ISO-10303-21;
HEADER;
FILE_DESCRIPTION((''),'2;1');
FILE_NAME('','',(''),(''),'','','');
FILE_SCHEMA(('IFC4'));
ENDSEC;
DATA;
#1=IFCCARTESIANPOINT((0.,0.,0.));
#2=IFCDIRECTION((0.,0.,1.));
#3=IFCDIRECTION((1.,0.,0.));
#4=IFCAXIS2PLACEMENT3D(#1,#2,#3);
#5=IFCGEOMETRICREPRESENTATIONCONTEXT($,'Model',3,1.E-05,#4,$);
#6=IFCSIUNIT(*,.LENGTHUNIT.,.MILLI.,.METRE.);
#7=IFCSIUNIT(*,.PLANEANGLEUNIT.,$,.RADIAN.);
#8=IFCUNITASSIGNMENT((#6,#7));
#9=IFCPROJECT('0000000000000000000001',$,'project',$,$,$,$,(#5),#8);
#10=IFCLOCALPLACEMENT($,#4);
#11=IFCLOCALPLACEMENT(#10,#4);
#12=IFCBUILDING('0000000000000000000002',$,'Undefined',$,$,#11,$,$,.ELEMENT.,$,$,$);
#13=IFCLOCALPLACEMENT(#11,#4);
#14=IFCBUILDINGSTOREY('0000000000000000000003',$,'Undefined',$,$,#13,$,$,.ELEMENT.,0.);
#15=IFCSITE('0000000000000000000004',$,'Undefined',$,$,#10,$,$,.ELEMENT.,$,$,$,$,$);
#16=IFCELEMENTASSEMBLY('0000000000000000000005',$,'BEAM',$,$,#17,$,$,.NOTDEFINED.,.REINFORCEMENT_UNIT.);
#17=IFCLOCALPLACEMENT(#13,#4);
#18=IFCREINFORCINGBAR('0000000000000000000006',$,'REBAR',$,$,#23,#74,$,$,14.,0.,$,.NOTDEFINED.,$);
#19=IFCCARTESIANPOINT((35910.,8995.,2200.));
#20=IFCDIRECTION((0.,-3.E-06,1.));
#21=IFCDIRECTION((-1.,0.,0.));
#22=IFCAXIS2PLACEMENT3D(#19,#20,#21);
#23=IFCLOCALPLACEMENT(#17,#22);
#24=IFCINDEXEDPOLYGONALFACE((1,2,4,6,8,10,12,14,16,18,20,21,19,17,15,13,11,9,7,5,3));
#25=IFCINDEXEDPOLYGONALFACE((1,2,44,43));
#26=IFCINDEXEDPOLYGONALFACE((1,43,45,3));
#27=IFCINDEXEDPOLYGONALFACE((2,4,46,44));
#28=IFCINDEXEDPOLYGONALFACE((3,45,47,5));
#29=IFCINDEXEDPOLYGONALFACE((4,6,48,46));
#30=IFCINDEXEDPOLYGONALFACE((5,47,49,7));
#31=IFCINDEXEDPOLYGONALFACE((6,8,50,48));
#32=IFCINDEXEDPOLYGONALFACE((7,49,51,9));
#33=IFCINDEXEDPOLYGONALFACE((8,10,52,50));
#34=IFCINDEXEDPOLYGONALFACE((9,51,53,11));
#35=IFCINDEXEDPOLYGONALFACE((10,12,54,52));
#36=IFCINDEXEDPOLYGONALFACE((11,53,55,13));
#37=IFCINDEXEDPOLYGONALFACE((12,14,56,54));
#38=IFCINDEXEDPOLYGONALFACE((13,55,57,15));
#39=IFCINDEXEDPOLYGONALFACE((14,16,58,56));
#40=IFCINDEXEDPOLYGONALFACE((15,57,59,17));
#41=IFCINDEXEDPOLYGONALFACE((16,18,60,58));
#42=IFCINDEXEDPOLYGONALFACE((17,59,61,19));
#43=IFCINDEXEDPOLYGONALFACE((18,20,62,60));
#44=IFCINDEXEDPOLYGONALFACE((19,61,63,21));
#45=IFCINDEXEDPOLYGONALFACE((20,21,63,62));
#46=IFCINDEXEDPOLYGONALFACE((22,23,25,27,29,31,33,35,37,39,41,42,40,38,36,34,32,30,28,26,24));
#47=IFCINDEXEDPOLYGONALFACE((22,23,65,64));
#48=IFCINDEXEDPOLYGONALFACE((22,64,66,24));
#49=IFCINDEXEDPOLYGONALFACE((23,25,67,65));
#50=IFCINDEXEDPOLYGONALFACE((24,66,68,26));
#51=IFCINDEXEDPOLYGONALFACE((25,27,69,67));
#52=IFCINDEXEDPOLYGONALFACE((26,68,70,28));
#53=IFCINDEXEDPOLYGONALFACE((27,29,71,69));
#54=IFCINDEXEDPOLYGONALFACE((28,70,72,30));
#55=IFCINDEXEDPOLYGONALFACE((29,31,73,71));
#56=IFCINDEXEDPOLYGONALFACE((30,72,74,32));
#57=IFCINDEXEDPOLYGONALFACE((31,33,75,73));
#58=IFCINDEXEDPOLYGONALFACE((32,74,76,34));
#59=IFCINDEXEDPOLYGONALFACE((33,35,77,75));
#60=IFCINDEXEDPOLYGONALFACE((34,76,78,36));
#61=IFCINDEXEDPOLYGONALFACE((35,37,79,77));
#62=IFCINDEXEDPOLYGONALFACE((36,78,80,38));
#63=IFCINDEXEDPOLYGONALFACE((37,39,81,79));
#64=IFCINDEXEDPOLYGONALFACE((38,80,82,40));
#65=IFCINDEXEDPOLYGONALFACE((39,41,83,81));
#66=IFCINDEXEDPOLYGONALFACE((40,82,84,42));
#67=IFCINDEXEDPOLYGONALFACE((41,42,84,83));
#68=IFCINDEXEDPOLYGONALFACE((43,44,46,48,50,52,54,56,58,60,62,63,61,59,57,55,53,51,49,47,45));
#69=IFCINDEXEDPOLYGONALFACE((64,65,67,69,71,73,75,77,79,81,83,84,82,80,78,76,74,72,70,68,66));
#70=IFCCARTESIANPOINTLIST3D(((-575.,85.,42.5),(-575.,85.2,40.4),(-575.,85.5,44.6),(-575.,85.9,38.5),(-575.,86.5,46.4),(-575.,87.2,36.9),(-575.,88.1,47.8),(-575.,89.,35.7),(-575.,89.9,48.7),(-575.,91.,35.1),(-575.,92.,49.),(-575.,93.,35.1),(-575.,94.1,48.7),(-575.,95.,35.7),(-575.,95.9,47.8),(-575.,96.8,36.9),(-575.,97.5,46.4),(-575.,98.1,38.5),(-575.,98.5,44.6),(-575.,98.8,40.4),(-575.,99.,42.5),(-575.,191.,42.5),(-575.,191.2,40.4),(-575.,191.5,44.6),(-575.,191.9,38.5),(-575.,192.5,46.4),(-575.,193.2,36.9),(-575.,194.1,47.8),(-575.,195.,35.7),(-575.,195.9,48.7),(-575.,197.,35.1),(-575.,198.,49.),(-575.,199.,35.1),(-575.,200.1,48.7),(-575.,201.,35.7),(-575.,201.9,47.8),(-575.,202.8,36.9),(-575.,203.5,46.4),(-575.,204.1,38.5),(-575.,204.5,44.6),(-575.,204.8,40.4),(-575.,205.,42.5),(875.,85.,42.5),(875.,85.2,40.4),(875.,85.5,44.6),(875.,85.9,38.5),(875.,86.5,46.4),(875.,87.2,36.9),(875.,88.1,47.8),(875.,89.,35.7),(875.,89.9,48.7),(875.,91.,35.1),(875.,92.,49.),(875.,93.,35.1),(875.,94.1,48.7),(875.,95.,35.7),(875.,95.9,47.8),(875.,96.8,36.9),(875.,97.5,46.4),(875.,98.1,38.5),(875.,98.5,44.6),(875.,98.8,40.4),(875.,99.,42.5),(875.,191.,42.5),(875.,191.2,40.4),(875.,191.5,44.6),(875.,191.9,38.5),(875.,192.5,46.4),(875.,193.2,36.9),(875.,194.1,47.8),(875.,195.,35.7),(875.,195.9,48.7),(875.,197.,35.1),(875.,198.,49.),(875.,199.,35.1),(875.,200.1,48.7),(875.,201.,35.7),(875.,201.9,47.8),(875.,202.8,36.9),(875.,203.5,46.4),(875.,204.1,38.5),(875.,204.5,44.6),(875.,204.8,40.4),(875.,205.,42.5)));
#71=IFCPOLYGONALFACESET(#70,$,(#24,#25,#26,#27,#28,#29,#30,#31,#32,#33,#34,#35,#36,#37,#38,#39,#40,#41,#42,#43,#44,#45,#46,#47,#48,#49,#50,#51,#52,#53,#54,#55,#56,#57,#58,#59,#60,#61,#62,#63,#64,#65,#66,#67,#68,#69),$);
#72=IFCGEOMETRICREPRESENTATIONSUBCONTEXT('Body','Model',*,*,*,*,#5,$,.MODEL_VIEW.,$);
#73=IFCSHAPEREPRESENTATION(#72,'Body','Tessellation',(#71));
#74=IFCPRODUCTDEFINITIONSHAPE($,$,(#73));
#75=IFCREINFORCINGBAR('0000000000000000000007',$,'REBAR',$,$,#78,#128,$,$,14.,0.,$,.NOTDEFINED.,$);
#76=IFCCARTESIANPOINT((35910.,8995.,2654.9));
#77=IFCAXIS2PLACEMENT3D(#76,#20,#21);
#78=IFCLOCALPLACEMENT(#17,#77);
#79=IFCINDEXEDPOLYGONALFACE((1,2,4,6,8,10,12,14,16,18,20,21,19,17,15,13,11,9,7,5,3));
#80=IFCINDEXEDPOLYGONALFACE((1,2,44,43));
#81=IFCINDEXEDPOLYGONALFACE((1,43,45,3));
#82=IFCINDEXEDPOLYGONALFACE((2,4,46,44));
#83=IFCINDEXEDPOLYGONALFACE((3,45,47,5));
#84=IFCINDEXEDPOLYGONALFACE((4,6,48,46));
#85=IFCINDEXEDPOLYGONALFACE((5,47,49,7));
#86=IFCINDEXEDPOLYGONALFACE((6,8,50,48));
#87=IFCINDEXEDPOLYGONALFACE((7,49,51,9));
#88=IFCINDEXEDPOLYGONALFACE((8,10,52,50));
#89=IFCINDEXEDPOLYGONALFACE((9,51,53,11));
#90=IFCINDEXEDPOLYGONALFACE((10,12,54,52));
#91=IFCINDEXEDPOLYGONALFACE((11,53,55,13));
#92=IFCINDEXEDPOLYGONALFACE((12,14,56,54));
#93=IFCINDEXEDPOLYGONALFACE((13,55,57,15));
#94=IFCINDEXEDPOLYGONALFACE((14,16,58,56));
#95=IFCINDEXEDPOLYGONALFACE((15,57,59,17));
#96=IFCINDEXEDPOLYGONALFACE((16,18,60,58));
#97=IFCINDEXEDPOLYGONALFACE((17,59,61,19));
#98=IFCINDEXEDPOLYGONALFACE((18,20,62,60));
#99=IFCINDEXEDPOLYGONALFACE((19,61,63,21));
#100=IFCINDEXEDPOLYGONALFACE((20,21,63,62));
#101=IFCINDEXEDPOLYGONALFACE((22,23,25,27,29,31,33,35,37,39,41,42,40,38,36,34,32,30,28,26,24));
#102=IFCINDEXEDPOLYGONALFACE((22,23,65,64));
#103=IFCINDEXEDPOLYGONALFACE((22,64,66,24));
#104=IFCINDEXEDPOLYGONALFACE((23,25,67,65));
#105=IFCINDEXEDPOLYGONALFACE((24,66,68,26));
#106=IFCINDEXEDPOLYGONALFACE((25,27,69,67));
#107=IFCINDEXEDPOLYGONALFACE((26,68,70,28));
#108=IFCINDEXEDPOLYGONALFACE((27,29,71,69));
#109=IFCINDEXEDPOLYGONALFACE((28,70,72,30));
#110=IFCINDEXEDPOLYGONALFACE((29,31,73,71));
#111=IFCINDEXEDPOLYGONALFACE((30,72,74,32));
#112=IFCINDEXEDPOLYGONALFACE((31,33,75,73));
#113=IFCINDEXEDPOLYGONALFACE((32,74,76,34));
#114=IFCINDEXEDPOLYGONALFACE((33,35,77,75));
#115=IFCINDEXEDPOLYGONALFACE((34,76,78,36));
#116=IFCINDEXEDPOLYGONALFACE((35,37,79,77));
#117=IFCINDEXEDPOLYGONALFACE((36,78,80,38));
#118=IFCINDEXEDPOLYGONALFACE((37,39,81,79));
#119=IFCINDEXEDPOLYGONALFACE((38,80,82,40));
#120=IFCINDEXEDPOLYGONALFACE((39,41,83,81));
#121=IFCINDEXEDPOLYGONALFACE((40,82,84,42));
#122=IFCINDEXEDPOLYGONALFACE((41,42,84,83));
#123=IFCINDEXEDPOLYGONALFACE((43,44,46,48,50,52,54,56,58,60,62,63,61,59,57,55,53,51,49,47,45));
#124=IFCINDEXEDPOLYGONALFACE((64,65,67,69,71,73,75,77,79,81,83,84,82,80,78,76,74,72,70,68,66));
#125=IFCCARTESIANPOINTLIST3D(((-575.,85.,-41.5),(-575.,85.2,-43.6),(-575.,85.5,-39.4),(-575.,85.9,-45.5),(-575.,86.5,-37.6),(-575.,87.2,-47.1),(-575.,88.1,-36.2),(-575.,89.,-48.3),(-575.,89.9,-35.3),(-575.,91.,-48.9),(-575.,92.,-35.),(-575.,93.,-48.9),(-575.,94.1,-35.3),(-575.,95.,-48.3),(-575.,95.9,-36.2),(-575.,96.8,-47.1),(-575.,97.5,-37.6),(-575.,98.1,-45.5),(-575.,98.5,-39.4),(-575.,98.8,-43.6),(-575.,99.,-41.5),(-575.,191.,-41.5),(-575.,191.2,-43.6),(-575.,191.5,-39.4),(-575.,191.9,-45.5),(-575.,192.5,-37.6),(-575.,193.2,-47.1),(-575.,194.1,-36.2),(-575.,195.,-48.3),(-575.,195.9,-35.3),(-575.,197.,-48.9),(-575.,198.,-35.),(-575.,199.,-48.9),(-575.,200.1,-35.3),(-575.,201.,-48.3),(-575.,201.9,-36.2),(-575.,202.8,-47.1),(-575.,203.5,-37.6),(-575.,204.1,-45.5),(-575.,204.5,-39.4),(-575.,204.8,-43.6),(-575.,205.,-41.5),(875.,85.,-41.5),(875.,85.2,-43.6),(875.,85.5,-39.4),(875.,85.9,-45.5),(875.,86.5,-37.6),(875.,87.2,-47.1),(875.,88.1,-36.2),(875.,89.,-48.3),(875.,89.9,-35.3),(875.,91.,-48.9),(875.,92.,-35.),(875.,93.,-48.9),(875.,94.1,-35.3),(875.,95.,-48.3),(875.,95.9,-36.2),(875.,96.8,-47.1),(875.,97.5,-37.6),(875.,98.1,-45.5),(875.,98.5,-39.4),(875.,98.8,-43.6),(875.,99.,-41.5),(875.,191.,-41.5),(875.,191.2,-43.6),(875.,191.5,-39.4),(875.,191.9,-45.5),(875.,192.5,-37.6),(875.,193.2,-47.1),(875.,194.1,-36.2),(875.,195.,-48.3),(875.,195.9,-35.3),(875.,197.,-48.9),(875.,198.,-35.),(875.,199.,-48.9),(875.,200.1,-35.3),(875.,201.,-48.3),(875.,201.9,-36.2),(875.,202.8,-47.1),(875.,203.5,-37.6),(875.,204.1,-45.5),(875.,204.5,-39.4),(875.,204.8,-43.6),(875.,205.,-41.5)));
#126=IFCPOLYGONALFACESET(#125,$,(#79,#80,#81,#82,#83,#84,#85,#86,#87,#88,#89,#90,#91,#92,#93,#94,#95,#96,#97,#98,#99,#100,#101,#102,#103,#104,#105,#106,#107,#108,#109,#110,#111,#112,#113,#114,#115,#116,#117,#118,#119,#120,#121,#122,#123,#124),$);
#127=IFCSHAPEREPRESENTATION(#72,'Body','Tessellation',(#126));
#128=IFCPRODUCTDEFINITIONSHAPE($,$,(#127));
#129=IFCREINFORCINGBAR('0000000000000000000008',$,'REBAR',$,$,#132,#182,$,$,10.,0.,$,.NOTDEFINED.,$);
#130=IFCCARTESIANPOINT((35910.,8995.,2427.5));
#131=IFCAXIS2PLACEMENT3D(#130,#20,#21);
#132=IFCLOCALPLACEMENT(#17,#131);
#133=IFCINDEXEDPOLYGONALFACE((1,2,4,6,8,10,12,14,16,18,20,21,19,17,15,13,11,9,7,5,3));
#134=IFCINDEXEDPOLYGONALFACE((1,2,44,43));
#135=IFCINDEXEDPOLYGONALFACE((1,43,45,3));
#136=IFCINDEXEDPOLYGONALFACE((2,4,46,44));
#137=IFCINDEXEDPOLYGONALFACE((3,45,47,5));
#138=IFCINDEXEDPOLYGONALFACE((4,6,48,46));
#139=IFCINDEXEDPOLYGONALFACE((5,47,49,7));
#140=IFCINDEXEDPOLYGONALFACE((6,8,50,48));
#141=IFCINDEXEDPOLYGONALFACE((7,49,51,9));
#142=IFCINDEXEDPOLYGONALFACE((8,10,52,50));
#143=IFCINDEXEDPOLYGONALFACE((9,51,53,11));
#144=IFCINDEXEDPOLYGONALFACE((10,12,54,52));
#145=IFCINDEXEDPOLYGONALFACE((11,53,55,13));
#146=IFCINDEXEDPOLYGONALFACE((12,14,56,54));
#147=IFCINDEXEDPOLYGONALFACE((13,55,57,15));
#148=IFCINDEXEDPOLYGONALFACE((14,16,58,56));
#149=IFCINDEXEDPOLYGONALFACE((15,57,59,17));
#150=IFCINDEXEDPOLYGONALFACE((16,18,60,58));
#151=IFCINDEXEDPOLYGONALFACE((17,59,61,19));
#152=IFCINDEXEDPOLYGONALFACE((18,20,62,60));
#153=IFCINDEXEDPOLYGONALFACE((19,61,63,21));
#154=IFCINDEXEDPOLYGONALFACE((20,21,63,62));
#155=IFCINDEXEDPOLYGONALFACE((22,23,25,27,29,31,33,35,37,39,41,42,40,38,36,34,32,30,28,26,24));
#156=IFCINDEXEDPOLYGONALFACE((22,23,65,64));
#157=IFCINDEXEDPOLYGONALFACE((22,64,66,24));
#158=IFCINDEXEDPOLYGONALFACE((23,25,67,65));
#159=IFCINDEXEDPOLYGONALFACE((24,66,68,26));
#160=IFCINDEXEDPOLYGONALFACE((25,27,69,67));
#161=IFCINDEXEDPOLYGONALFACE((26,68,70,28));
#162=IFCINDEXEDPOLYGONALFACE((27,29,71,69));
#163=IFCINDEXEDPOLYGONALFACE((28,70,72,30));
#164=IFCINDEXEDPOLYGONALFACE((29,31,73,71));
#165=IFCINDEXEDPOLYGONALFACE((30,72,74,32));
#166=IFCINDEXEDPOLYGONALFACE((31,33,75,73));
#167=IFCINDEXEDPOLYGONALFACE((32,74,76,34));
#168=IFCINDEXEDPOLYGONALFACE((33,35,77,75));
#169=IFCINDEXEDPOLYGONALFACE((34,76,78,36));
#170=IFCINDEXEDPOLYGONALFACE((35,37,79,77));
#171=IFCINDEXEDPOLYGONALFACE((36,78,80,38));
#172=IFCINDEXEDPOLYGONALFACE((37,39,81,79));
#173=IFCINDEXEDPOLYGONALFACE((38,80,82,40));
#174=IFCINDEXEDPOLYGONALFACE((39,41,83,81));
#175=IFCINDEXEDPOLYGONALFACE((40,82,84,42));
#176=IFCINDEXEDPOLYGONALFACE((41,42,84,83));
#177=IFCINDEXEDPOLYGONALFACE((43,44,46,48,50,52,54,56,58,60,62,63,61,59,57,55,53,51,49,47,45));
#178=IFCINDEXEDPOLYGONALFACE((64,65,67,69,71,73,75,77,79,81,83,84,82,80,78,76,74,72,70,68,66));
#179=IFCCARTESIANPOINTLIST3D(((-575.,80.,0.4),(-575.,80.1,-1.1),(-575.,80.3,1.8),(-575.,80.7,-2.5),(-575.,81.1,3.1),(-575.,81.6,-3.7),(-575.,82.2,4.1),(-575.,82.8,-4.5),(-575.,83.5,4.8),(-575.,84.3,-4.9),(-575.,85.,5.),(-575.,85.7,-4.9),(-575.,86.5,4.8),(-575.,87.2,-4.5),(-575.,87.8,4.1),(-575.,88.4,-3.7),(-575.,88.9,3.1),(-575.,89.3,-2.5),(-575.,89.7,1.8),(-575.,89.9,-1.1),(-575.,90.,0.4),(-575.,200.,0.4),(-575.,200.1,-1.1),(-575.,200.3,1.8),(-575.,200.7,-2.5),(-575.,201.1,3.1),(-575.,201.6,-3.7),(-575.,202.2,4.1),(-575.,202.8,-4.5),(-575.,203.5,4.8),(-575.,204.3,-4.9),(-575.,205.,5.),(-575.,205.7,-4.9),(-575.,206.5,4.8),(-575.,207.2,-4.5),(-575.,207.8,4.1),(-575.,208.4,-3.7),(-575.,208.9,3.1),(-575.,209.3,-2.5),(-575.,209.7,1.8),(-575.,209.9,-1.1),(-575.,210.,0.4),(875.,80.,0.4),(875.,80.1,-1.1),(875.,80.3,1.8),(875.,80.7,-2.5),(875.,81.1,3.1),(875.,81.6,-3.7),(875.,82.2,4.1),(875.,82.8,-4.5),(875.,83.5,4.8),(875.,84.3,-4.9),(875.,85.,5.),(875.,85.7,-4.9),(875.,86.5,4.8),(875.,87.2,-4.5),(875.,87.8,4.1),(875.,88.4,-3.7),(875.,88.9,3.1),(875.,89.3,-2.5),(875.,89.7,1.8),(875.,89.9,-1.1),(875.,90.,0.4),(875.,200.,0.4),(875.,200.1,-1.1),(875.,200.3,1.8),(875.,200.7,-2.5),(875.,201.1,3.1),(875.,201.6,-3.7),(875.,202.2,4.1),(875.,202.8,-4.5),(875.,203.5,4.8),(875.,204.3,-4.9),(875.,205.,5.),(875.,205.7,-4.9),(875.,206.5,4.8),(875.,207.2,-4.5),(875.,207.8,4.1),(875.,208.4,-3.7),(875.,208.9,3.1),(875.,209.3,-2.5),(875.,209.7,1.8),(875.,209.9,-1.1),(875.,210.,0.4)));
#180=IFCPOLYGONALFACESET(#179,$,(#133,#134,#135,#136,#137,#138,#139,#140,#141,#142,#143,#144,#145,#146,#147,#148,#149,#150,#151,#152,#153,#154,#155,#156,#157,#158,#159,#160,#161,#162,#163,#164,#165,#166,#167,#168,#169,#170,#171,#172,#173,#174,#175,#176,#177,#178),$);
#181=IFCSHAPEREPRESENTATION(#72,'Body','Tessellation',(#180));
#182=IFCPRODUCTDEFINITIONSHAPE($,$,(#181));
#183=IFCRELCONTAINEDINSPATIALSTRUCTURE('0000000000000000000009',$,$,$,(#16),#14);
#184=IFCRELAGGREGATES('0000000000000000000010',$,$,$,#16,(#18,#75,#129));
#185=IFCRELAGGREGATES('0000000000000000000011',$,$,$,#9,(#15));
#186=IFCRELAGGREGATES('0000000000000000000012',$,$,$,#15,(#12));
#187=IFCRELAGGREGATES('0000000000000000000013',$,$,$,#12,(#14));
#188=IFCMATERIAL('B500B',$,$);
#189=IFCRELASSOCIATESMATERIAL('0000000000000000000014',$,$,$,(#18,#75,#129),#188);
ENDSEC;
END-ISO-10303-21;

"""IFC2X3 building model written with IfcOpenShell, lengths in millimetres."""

from ifc_helpers import new_model, entity, si_unit, frame, origin_with_axes, place, context, subcontext, project, spatial, source, transform, mapped, material, element, aggregate, save


model = new_model("IFC2X3")

# Units and contexts
model_context = context("Model", 3, precision=1e-05, world=origin_with_axes())
body_context = subcontext(model_context, "Body", "Model", "MODEL_VIEW")
ifc_project = project(units=[si_unit("LENGTHUNIT", "METRE", prefix="MILLI"), si_unit("PLANEANGLEUNIT", "RADIAN")], contexts=[model_context])

# Site, building, storey
site_placement = place(None, origin_with_axes())
site = spatial("IfcSite", under=ifc_project, at=site_placement, Name="Undefined", CompositionType="ELEMENT")
building_placement = place(site_placement, origin_with_axes())
building = spatial("IfcBuilding", under=site, at=building_placement, Name="Undefined", CompositionType="ELEMENT")
storey_placement = place(building_placement, origin_with_axes())
storey = spatial("IfcBuildingStorey", under=building, at=storey_placement, Name="Undefined", CompositionType="ELEMENT", Elevation=0.0)

# Shared definitions
ifc_material_1 = material(Name="B500B")

# Element assembly, reinforcing bars
assembly_1_placement = place(storey_placement, origin_with_axes())
assembly_1 = element("IfcElementAssembly", 1, at=assembly_1_placement, inside=storey, Name="BEAM", AssemblyPlace="NOTDEFINED", PredefinedType="REINFORCEMENT_UNIT")
shared_shape_1 = source(origin_with_axes(), body_context, "Body", "AdvancedSweptSolid", [
    entity("IfcSweptDiskSolid", entity("IfcTrimmedCurve", entity("IfcLine", entity("IfcCartesianPoint", [0.0, 0.0, 0.0]), entity("IfcVector", entity("IfcDirection", [1.0, 0.0, 0.0]), 1.0)), [entity("IfcParameterValue", 0.0)], [entity("IfcParameterValue", 1449.999613)], True, "PARAMETER"), 7.0, None, 0.0, 1450.0),
])
shared_shape_2 = source(origin_with_axes(), body_context, "Body", "AdvancedSweptSolid", [
    entity("IfcSweptDiskSolid", entity("IfcTrimmedCurve", entity("IfcLine", entity("IfcCartesianPoint", [0.0, 0.0, 0.0]), entity("IfcVector", entity("IfcDirection", [1.0, 0.0, 0.0]), 1.0)), [entity("IfcParameterValue", 0.0)], [entity("IfcParameterValue", 1449.999613)], True, "PARAMETER"), 7.0, None, 0.0, 1450.0),
])
reinforcing_bar_1_placement = place(assembly_1_placement, frame((35910.0, 8995.0, 2200.0), z_axis=(0.0, -0.000003, 1.0), x_axis=(-1.0, 0.0, 0.0)))
reinforcing_bar_1 = element("IfcReinforcingBar", 2, at=reinforcing_bar_1_placement, material=ifc_material_1, Name="REBAR", BarRole="NOTDEFINED", CrossSectionArea=0.0, NominalDiameter=14.0, context=body_context, shape_type="MappedRepresentation", body=[
    mapped(shared_shape_1, transform((-575.0, 92.0, 42.0))),
    mapped(shared_shape_2, transform((-575.0, 198.0, 42.0))),
])
shared_shape_3 = source(origin_with_axes(), body_context, "Body", "AdvancedSweptSolid", [
    entity("IfcSweptDiskSolid", entity("IfcTrimmedCurve", entity("IfcLine", entity("IfcCartesianPoint", [0.0, 0.0, 0.0]), entity("IfcVector", entity("IfcDirection", [1.0, 0.0, 0.0]), 1.0)), [entity("IfcParameterValue", 0.0)], [entity("IfcParameterValue", 1449.999613)], True, "PARAMETER"), 7.0, None, 0.0, 1450.0),
])
shared_shape_4 = source(origin_with_axes(), body_context, "Body", "AdvancedSweptSolid", [
    entity("IfcSweptDiskSolid", entity("IfcTrimmedCurve", entity("IfcLine", entity("IfcCartesianPoint", [0.0, 0.0, 0.0]), entity("IfcVector", entity("IfcDirection", [1.0, 0.0, 0.0]), 1.0)), [entity("IfcParameterValue", 0.0)], [entity("IfcParameterValue", 1449.999613)], True, "PARAMETER"), 7.0, None, 0.0, 1450.0),
])
reinforcing_bar_2_placement = place(assembly_1_placement, frame((35910.0, 8995.0, 2654.9), z_axis=(0.0, -0.000003, 1.0), x_axis=(-1.0, 0.0, 0.0)))
reinforcing_bar_2 = element("IfcReinforcingBar", 3, at=reinforcing_bar_2_placement, material=ifc_material_1, Name="REBAR", BarRole="NOTDEFINED", CrossSectionArea=0.0, NominalDiameter=14.0, context=body_context, shape_type="MappedRepresentation", body=[
    mapped(shared_shape_3, transform((-575.0, 92.0, -42.0))),
    mapped(shared_shape_4, transform((-575.0, 198.0, -42.0))),
])
shared_shape_5 = source(origin_with_axes(), body_context, "Body", "AdvancedSweptSolid", [
    entity("IfcSweptDiskSolid", entity("IfcTrimmedCurve", entity("IfcLine", entity("IfcCartesianPoint", [0.0, 0.0, 0.0]), entity("IfcVector", entity("IfcDirection", [1.0, 0.0, 0.0]), 1.0)), [entity("IfcParameterValue", 0.0)], [entity("IfcParameterValue", 1449.999613)], True, "PARAMETER"), 5.0, None, 0.0, 1450.0),
])
shared_shape_6 = source(origin_with_axes(), body_context, "Body", "AdvancedSweptSolid", [
    entity("IfcSweptDiskSolid", entity("IfcTrimmedCurve", entity("IfcLine", entity("IfcCartesianPoint", [0.0, 0.0, 0.0]), entity("IfcVector", entity("IfcDirection", [1.0, 0.0, 0.0]), 1.0)), [entity("IfcParameterValue", 0.0)], [entity("IfcParameterValue", 1449.999613)], True, "PARAMETER"), 5.0, None, 0.0, 1450.0),
])
reinforcing_bar_3_placement = place(assembly_1_placement, frame((35910.0, 8995.0, 2427.5), z_axis=(0.0, -0.000003, 1.0), x_axis=(-1.0, 0.0, 0.0)))
reinforcing_bar_3 = element("IfcReinforcingBar", 4, at=reinforcing_bar_3_placement, material=ifc_material_1, Name="REBAR", BarRole="NOTDEFINED", CrossSectionArea=0.0, NominalDiameter=10.0, context=body_context, shape_type="MappedRepresentation", body=[
    mapped(shared_shape_5, transform((-575.0, 85.0, 0.0))),
    mapped(shared_shape_6, transform((-575.0, 205.0, 0.0))),
])
aggregate(assembly_1, [reinforcing_bar_1, reinforcing_bar_2, reinforcing_bar_3])

save(model, "model.ifc")
